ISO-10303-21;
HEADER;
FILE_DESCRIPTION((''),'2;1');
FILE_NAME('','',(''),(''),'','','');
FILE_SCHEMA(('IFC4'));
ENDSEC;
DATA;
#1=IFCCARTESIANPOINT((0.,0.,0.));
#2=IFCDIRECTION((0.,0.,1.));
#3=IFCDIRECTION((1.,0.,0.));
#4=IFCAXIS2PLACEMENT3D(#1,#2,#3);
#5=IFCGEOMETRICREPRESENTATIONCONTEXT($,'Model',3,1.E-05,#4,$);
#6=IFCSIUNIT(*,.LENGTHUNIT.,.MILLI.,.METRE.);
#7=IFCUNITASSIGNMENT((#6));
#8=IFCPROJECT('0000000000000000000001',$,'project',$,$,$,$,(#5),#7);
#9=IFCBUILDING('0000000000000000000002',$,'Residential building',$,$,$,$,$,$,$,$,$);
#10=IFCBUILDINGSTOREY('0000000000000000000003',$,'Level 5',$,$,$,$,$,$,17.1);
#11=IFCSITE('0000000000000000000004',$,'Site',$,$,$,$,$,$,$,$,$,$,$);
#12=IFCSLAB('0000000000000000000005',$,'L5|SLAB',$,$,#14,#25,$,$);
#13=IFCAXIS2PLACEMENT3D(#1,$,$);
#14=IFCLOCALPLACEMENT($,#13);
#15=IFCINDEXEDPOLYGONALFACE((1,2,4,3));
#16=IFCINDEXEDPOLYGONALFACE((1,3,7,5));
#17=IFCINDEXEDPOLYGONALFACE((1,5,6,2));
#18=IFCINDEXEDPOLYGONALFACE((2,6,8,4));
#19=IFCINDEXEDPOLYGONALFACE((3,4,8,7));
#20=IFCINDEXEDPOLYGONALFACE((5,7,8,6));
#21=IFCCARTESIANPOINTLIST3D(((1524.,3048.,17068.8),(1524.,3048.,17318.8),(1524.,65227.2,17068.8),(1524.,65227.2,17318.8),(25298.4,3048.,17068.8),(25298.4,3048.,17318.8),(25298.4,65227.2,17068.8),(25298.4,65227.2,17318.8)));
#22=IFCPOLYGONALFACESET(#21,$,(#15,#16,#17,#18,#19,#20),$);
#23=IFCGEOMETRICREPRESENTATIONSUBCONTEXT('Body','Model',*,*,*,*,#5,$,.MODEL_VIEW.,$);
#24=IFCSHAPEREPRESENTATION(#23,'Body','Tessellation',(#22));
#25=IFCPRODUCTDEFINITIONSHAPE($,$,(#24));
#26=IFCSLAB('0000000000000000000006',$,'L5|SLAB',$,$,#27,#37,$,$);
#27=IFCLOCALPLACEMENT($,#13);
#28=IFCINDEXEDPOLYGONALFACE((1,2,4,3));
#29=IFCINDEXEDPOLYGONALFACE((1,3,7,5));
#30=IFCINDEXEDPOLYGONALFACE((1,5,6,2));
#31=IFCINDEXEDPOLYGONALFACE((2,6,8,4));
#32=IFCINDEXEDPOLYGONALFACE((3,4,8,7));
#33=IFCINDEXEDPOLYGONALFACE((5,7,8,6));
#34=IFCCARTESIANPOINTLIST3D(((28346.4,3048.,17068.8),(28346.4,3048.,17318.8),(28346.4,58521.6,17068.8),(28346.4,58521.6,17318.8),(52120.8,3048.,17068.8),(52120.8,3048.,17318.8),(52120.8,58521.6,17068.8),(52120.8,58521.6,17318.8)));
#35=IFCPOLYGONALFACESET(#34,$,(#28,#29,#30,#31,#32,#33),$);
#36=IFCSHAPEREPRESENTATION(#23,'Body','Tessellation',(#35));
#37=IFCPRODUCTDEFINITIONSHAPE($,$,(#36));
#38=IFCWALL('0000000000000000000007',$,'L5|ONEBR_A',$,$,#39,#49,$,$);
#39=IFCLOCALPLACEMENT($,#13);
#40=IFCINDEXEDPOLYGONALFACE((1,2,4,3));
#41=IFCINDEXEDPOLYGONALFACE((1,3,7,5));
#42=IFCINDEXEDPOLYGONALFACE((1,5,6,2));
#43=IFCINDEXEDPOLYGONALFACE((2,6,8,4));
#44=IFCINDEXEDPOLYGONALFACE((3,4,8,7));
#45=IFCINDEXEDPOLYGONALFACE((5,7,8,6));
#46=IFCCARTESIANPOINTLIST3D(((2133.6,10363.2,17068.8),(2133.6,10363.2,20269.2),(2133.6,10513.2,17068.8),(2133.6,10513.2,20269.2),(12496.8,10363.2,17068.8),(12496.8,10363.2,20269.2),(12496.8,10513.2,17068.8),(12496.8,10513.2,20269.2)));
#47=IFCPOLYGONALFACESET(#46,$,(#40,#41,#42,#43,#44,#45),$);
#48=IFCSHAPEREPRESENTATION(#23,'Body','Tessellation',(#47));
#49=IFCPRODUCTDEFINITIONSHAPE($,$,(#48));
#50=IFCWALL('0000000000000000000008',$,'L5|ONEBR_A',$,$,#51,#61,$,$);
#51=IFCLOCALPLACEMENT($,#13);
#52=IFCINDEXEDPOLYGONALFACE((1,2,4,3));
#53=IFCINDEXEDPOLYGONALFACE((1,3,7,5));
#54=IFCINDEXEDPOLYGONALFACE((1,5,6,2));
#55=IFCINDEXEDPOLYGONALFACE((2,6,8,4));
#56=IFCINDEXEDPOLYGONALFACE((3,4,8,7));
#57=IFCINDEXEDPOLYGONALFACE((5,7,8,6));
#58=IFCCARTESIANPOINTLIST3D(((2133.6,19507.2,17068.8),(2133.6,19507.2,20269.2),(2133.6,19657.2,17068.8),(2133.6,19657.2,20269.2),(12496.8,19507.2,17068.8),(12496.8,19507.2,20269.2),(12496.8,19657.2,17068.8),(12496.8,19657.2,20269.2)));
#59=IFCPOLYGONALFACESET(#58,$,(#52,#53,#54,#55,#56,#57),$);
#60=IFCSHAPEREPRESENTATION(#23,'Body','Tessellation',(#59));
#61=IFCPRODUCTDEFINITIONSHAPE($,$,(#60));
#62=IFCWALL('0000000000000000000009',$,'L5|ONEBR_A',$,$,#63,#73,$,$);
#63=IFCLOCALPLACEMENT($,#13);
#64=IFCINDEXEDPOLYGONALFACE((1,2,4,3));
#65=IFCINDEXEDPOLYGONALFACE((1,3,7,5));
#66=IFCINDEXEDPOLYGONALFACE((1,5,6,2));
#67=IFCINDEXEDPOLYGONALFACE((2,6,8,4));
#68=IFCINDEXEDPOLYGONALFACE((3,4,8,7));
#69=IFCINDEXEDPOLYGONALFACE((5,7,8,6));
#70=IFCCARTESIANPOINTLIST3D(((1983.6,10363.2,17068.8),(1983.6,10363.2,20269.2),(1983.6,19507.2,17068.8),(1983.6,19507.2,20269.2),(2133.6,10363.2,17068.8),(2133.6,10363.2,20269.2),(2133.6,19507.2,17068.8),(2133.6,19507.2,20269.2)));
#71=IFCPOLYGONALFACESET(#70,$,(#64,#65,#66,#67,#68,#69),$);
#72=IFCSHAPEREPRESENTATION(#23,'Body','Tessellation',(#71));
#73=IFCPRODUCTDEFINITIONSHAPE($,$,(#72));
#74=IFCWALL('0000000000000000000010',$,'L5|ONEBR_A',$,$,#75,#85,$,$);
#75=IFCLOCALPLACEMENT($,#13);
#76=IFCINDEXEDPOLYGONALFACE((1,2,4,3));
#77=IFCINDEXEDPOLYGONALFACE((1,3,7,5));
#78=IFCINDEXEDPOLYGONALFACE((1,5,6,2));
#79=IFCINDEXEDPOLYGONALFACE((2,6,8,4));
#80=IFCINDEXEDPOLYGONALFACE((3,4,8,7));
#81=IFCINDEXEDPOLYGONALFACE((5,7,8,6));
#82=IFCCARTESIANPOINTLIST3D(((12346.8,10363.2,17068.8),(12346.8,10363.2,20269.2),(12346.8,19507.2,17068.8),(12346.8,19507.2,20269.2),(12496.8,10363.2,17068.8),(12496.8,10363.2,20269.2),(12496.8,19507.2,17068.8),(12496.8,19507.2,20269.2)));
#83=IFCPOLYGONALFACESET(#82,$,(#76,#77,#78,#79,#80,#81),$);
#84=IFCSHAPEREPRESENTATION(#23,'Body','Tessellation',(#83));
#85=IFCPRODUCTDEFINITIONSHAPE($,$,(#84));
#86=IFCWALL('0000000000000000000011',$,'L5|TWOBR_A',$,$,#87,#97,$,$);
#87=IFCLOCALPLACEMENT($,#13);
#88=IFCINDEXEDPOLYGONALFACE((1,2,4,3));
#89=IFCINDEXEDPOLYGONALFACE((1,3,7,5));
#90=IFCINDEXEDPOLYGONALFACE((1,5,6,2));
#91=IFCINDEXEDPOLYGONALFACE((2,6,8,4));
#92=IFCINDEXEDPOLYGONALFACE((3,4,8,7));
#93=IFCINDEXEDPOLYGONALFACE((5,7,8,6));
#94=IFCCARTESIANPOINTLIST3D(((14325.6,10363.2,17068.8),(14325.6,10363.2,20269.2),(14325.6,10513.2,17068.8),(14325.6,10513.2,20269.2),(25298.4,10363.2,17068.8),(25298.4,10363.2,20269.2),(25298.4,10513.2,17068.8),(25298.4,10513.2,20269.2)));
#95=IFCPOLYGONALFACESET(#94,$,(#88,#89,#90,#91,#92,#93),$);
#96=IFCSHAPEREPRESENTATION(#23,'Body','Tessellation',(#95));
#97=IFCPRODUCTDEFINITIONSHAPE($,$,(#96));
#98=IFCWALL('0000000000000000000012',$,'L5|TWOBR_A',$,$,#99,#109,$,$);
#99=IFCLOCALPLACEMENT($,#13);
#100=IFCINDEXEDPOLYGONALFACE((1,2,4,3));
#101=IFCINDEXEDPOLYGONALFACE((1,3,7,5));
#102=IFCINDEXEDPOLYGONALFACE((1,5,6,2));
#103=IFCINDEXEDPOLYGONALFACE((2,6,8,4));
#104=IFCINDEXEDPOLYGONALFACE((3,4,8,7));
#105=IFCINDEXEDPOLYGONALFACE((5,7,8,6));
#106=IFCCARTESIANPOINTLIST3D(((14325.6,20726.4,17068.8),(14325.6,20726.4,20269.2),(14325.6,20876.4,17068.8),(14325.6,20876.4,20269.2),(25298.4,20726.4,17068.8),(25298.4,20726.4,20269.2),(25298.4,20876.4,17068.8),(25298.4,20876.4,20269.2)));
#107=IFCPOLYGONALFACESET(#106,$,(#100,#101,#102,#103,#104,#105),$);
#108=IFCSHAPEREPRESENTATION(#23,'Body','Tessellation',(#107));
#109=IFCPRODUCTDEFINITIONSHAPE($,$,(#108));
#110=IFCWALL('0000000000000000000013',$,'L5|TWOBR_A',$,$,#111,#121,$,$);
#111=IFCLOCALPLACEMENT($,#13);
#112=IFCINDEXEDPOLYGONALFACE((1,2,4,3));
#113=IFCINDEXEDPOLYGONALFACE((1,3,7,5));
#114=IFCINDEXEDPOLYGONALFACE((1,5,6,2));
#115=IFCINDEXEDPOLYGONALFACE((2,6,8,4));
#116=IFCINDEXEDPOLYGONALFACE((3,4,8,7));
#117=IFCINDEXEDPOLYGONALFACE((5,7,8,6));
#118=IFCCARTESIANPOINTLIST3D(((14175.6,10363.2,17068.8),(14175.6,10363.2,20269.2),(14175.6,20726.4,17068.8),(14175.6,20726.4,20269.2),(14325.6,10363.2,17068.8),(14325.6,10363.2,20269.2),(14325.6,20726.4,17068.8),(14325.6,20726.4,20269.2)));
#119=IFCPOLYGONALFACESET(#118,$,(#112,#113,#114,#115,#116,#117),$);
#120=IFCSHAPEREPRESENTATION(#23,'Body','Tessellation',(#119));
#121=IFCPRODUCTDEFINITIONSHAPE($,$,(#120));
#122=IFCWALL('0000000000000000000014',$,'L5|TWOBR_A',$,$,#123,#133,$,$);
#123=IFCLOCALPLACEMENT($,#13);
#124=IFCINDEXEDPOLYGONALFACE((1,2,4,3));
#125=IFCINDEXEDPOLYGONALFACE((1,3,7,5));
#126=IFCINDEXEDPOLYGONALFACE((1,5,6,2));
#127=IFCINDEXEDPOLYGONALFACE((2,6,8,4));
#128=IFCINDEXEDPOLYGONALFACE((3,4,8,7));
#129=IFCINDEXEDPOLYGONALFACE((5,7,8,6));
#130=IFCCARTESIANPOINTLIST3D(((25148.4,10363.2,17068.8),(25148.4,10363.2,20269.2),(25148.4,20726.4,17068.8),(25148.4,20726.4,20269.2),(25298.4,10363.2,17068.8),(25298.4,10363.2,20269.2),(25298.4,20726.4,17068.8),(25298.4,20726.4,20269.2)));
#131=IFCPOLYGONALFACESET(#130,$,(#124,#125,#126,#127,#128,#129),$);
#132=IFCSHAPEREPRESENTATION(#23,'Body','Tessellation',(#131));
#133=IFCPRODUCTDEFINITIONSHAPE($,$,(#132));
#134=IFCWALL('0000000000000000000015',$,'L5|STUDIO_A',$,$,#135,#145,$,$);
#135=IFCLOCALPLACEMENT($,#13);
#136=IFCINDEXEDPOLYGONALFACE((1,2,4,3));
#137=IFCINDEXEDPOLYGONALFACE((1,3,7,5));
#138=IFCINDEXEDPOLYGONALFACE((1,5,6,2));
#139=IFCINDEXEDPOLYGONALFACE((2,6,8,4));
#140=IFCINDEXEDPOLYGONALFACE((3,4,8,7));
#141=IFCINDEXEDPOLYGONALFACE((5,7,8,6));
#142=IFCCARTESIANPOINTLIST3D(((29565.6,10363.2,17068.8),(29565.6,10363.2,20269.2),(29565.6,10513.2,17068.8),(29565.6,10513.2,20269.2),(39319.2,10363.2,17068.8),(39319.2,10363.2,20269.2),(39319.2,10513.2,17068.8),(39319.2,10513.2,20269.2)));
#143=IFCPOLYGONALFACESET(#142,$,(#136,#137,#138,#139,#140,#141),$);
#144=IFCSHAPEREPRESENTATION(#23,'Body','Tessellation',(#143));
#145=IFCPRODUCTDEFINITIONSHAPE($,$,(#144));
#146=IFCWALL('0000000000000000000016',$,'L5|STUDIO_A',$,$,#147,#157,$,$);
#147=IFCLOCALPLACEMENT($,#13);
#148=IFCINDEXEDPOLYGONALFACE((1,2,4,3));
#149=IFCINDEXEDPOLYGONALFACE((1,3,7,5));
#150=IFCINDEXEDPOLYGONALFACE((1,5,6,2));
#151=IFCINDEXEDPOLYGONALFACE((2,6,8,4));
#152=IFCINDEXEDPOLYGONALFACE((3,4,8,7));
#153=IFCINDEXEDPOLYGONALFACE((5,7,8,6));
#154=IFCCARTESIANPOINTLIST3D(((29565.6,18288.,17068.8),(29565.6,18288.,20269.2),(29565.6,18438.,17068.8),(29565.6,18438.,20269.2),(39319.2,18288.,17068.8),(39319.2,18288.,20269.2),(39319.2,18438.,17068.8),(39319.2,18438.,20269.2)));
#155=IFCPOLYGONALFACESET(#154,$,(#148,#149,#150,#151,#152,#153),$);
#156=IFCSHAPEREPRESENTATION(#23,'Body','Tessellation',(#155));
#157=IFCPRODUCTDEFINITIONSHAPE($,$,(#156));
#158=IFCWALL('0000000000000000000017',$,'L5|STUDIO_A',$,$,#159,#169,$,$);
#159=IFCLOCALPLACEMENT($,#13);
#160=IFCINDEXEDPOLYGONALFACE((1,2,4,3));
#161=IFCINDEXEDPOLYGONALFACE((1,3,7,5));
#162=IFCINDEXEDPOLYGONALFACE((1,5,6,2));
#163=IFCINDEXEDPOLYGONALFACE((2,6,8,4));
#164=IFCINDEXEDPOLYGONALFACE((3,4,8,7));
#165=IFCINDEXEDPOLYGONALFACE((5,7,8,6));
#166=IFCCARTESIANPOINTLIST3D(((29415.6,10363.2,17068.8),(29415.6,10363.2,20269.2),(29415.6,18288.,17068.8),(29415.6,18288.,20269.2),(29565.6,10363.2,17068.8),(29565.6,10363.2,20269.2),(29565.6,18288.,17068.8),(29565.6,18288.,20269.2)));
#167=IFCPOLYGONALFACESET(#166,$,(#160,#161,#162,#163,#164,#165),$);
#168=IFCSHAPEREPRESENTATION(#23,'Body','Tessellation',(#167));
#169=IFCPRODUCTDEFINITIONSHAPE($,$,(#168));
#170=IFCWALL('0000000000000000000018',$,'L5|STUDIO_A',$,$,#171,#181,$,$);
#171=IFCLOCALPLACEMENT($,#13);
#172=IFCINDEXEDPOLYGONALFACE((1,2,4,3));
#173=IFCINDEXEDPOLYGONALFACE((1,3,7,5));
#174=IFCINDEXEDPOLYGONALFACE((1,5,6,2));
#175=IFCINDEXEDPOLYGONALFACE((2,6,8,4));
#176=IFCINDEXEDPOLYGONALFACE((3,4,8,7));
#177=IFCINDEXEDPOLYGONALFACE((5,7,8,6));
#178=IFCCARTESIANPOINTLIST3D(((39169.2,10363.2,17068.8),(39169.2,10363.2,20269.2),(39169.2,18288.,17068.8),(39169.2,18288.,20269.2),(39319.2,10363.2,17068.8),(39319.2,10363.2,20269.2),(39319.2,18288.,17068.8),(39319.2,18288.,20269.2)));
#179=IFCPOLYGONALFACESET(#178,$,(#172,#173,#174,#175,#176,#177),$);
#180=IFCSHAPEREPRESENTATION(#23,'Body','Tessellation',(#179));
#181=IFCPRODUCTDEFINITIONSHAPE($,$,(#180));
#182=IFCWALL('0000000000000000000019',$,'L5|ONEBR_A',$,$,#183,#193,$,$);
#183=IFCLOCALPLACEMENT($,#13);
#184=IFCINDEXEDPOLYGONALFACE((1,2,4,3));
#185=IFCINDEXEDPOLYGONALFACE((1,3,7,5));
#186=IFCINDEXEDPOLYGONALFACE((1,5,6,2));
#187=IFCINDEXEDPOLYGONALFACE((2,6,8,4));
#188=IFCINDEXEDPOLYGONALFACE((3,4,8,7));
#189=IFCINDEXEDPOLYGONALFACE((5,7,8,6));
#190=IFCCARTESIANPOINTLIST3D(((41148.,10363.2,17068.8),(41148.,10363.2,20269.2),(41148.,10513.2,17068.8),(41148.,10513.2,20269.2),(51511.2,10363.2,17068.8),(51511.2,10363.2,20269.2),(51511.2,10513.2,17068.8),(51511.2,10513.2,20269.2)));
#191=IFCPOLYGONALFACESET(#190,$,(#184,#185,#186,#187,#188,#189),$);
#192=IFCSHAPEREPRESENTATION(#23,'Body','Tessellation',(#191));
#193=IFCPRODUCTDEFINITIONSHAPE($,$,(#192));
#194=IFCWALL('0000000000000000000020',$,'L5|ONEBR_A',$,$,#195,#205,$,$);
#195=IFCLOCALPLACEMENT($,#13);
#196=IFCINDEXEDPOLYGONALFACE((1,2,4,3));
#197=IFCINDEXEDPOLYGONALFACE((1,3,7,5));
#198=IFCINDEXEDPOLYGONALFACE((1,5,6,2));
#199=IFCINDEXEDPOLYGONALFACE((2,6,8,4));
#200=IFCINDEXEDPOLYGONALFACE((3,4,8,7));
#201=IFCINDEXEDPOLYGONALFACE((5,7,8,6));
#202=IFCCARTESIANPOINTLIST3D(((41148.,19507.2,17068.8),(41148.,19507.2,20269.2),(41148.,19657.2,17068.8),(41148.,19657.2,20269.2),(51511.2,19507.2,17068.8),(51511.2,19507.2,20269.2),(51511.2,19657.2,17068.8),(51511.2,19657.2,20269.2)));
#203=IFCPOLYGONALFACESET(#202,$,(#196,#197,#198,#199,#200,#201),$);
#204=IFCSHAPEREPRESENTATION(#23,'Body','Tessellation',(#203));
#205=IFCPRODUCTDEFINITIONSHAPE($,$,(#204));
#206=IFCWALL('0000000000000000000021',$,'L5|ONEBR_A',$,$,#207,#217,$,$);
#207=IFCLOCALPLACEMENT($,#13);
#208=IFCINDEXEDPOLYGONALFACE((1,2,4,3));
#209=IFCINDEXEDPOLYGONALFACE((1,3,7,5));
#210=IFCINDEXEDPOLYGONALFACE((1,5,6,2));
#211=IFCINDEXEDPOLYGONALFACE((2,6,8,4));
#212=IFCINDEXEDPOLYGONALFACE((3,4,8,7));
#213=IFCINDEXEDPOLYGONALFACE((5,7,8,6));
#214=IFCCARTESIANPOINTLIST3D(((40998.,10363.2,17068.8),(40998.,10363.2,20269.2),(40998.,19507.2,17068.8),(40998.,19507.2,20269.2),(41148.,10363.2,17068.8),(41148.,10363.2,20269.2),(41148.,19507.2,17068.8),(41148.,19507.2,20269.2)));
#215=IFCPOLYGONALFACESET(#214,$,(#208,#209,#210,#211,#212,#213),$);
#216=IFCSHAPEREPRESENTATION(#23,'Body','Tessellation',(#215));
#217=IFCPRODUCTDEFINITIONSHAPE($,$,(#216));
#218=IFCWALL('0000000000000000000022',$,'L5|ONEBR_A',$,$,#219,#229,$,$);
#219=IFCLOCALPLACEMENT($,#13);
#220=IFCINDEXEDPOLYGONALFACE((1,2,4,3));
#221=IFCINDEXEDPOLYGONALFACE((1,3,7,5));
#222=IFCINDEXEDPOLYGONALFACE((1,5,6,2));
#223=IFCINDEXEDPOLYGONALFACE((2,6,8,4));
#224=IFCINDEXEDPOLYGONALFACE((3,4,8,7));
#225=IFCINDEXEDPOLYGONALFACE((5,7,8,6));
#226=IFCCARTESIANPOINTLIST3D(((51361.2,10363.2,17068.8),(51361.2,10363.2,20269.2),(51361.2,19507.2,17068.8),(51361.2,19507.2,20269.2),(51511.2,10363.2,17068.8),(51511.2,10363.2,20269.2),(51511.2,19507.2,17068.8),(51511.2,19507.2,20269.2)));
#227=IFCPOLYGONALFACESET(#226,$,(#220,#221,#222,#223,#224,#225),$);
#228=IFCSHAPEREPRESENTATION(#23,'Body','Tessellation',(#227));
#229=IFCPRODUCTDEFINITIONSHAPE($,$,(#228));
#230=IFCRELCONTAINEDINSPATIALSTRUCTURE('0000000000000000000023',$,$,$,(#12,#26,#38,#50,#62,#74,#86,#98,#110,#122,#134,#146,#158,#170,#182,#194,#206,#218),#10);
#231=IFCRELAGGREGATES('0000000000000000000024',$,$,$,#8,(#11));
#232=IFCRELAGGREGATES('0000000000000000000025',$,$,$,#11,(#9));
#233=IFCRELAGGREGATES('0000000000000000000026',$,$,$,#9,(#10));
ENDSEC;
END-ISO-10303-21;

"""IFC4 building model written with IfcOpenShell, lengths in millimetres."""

from ifc_helpers import new_model, si_unit, frame, origin_with_axes, place, context, subcontext, project, spatial, indexed_curve, outline, extrude, element, save


model = new_model("IFC4")

# Units and contexts
model_context = context("Model", 3, precision=1e-05, world=origin_with_axes())
body_context = subcontext(model_context, "Body", "Model", "MODEL_VIEW")
ifc_project = project(units=[si_unit("LENGTHUNIT", "METRE", prefix="MILLI")], contexts=[model_context])

# Site, building, storey
site = spatial("IfcSite", under=ifc_project, Name="Site")
building = spatial("IfcBuilding", under=site, Name="Residential building")
storey = spatial("IfcBuildingStorey", under=building, Name="Level 5", Elevation=17.1)

# Slabs
slab_1_placement = place(None, frame((1524.0, 3048.0, 17068.8), z_axis=(0.0, 0.0, 1.0), x_axis=(1.0, 0.0, 0.0)))
element("IfcSlab", 1, at=slab_1_placement, inside=storey, Name="L5|SLAB", context=body_context, shape_type="SweptSolid", body=[
    extrude(outline(indexed_curve([(0.0, 0.0), (23774.4, 0.0), (23774.4, 62179.2), (0.0, 62179.2), (0.0, 0.0)])), None, (0.0, 0.0, 1.0), 250.0),
])
slab_2_placement = place(None, frame((28346.4, 3048.0, 17068.8), z_axis=(0.0, 0.0, 1.0), x_axis=(1.0, 0.0, 0.0)))
element("IfcSlab", 2, at=slab_2_placement, inside=storey, Name="L5|SLAB", context=body_context, shape_type="SweptSolid", body=[
    extrude(outline(indexed_curve([(0.0, 0.0), (23774.4, 0.0), (23774.4, 55473.6), (0.0, 55473.6), (0.0, 0.0)])), None, (0.0, 0.0, 1.0), 250.0),
])

# Walls
for number, where, z_axis, x_axis, name in (
    (3, (2133.6, 10363.2, 17068.8), (0.0, 0.0, 1.0), (1.0, 0.0, 0.0), "L5|ONEBR_A"),
    (4, (2133.6, 19507.2, 17068.8), (0.0, 0.0, 1.0), (1.0, 0.0, 0.0), "L5|ONEBR_A"),
):
    element("IfcWall", number, at=place(None, frame(where, z_axis=z_axis, x_axis=x_axis)), inside=storey, Name=name, context=body_context, shape_type="SweptSolid", body=[
        extrude(outline(indexed_curve([(0.0, 0.0), (0.0, 150.0), (10363.2, 150.0), (10363.2, 0.0), (0.0, 0.0)], self_intersect=False)), origin_with_axes(), (0.0, 0.0, 1.0), 3200.4),
    ])
for number, where, z_axis, x_axis, name in (
    (5, (2133.6, 10363.2, 17068.8), (0.0, 0.0, 1.0), (0.0, 1.0, 0.0), "L5|ONEBR_A"),
    (6, (12496.8, 10363.2, 17068.8), (0.0, 0.0, 1.0), (0.0, 1.0, 0.0), "L5|ONEBR_A"),
):
    element("IfcWall", number, at=place(None, frame(where, z_axis=z_axis, x_axis=x_axis)), inside=storey, Name=name, context=body_context, shape_type="SweptSolid", body=[
        extrude(outline(indexed_curve([(0.0, 0.0), (0.0, 150.0), (9144.0, 150.0), (9144.0, 0.0), (0.0, 0.0)], self_intersect=False)), origin_with_axes(), (0.0, 0.0, 1.0), 3200.4),
    ])
for number, where, z_axis, x_axis, name in (
    (7, (14325.6, 10363.2, 17068.8), (0.0, 0.0, 1.0), (1.0, 0.0, 0.0), "L5|TWOBR_A"),
    (8, (14325.6, 20726.4, 17068.8), (0.0, 0.0, 1.0), (1.0, 0.0, 0.0), "L5|TWOBR_A"),
):
    element("IfcWall", number, at=place(None, frame(where, z_axis=z_axis, x_axis=x_axis)), inside=storey, Name=name, context=body_context, shape_type="SweptSolid", body=[
        extrude(outline(indexed_curve([(0.0, 0.0), (0.0, 150.0), (10972.8, 150.0), (10972.8, 0.0), (0.0, 0.0)], self_intersect=False)), origin_with_axes(), (0.0, 0.0, 1.0), 3200.4),
    ])
for number, where, z_axis, x_axis, name in (
    (9, (14325.6, 10363.2, 17068.8), (0.0, 0.0, 1.0), (0.0, 1.0, 0.0), "L5|TWOBR_A"),
    (10, (25298.4, 10363.2, 17068.8), (0.0, 0.0, 1.0), (0.0, 1.0, 0.0), "L5|TWOBR_A"),
):
    element("IfcWall", number, at=place(None, frame(where, z_axis=z_axis, x_axis=x_axis)), inside=storey, Name=name, context=body_context, shape_type="SweptSolid", body=[
        extrude(outline(indexed_curve([(0.0, 0.0), (0.0, 150.0), (10363.2, 150.0), (10363.2, 0.0), (0.0, 0.0)], self_intersect=False)), origin_with_axes(), (0.0, 0.0, 1.0), 3200.4),
    ])
for number, where, z_axis, x_axis, name in (
    (11, (29565.6, 10363.2, 17068.8), (0.0, 0.0, 1.0), (1.0, 0.0, 0.0), "L5|STUDIO_A"),
    (12, (29565.6, 18288.0, 17068.8), (0.0, 0.0, 1.0), (1.0, 0.0, 0.0), "L5|STUDIO_A"),
):
    element("IfcWall", number, at=place(None, frame(where, z_axis=z_axis, x_axis=x_axis)), inside=storey, Name=name, context=body_context, shape_type="SweptSolid", body=[
        extrude(outline(indexed_curve([(0.0, 0.0), (0.0, 150.0), (9753.6, 150.0), (9753.6, 0.0), (0.0, 0.0)], self_intersect=False)), origin_with_axes(), (0.0, 0.0, 1.0), 3200.4),
    ])
for number, where, z_axis, x_axis, name in (
    (13, (29565.6, 10363.2, 17068.8), (0.0, 0.0, 1.0), (0.0, 1.0, 0.0), "L5|STUDIO_A"),
    (14, (39319.2, 10363.2, 17068.8), (0.0, 0.0, 1.0), (0.0, 1.0, 0.0), "L5|STUDIO_A"),
):
    element("IfcWall", number, at=place(None, frame(where, z_axis=z_axis, x_axis=x_axis)), inside=storey, Name=name, context=body_context, shape_type="SweptSolid", body=[
        extrude(outline(indexed_curve([(0.0, 0.0), (0.0, 150.0), (7924.8, 150.0), (7924.8, 0.0), (0.0, 0.0)], self_intersect=False)), origin_with_axes(), (0.0, 0.0, 1.0), 3200.4),
    ])
for number, where, z_axis, x_axis, name in (
    (15, (41148.0, 10363.2, 17068.8), (0.0, 0.0, 1.0), (1.0, 0.0, 0.0), "L5|ONEBR_A"),
    (16, (41148.0, 19507.2, 17068.8), (0.0, 0.0, 1.0), (1.0, 0.0, 0.0), "L5|ONEBR_A"),
):
    element("IfcWall", number, at=place(None, frame(where, z_axis=z_axis, x_axis=x_axis)), inside=storey, Name=name, context=body_context, shape_type="SweptSolid", body=[
        extrude(outline(indexed_curve([(0.0, 0.0), (0.0, 150.0), (10363.2, 150.0), (10363.2, 0.0), (0.0, 0.0)], self_intersect=False)), origin_with_axes(), (0.0, 0.0, 1.0), 3200.4),
    ])
for number, where, z_axis, x_axis, name in (
    (17, (41148.0, 10363.2, 17068.8), (0.0, 0.0, 1.0), (0.0, 1.0, 0.0), "L5|ONEBR_A"),
    (18, (51511.2, 10363.2, 17068.8), (0.0, 0.0, 1.0), (0.0, 1.0, 0.0), "L5|ONEBR_A"),
):
    element("IfcWall", number, at=place(None, frame(where, z_axis=z_axis, x_axis=x_axis)), inside=storey, Name=name, context=body_context, shape_type="SweptSolid", body=[
        extrude(outline(indexed_curve([(0.0, 0.0), (0.0, 150.0), (9144.0, 150.0), (9144.0, 0.0), (0.0, 0.0)], self_intersect=False)), origin_with_axes(), (0.0, 0.0, 1.0), 3200.4),
    ])

save(model, "model.ifc")
